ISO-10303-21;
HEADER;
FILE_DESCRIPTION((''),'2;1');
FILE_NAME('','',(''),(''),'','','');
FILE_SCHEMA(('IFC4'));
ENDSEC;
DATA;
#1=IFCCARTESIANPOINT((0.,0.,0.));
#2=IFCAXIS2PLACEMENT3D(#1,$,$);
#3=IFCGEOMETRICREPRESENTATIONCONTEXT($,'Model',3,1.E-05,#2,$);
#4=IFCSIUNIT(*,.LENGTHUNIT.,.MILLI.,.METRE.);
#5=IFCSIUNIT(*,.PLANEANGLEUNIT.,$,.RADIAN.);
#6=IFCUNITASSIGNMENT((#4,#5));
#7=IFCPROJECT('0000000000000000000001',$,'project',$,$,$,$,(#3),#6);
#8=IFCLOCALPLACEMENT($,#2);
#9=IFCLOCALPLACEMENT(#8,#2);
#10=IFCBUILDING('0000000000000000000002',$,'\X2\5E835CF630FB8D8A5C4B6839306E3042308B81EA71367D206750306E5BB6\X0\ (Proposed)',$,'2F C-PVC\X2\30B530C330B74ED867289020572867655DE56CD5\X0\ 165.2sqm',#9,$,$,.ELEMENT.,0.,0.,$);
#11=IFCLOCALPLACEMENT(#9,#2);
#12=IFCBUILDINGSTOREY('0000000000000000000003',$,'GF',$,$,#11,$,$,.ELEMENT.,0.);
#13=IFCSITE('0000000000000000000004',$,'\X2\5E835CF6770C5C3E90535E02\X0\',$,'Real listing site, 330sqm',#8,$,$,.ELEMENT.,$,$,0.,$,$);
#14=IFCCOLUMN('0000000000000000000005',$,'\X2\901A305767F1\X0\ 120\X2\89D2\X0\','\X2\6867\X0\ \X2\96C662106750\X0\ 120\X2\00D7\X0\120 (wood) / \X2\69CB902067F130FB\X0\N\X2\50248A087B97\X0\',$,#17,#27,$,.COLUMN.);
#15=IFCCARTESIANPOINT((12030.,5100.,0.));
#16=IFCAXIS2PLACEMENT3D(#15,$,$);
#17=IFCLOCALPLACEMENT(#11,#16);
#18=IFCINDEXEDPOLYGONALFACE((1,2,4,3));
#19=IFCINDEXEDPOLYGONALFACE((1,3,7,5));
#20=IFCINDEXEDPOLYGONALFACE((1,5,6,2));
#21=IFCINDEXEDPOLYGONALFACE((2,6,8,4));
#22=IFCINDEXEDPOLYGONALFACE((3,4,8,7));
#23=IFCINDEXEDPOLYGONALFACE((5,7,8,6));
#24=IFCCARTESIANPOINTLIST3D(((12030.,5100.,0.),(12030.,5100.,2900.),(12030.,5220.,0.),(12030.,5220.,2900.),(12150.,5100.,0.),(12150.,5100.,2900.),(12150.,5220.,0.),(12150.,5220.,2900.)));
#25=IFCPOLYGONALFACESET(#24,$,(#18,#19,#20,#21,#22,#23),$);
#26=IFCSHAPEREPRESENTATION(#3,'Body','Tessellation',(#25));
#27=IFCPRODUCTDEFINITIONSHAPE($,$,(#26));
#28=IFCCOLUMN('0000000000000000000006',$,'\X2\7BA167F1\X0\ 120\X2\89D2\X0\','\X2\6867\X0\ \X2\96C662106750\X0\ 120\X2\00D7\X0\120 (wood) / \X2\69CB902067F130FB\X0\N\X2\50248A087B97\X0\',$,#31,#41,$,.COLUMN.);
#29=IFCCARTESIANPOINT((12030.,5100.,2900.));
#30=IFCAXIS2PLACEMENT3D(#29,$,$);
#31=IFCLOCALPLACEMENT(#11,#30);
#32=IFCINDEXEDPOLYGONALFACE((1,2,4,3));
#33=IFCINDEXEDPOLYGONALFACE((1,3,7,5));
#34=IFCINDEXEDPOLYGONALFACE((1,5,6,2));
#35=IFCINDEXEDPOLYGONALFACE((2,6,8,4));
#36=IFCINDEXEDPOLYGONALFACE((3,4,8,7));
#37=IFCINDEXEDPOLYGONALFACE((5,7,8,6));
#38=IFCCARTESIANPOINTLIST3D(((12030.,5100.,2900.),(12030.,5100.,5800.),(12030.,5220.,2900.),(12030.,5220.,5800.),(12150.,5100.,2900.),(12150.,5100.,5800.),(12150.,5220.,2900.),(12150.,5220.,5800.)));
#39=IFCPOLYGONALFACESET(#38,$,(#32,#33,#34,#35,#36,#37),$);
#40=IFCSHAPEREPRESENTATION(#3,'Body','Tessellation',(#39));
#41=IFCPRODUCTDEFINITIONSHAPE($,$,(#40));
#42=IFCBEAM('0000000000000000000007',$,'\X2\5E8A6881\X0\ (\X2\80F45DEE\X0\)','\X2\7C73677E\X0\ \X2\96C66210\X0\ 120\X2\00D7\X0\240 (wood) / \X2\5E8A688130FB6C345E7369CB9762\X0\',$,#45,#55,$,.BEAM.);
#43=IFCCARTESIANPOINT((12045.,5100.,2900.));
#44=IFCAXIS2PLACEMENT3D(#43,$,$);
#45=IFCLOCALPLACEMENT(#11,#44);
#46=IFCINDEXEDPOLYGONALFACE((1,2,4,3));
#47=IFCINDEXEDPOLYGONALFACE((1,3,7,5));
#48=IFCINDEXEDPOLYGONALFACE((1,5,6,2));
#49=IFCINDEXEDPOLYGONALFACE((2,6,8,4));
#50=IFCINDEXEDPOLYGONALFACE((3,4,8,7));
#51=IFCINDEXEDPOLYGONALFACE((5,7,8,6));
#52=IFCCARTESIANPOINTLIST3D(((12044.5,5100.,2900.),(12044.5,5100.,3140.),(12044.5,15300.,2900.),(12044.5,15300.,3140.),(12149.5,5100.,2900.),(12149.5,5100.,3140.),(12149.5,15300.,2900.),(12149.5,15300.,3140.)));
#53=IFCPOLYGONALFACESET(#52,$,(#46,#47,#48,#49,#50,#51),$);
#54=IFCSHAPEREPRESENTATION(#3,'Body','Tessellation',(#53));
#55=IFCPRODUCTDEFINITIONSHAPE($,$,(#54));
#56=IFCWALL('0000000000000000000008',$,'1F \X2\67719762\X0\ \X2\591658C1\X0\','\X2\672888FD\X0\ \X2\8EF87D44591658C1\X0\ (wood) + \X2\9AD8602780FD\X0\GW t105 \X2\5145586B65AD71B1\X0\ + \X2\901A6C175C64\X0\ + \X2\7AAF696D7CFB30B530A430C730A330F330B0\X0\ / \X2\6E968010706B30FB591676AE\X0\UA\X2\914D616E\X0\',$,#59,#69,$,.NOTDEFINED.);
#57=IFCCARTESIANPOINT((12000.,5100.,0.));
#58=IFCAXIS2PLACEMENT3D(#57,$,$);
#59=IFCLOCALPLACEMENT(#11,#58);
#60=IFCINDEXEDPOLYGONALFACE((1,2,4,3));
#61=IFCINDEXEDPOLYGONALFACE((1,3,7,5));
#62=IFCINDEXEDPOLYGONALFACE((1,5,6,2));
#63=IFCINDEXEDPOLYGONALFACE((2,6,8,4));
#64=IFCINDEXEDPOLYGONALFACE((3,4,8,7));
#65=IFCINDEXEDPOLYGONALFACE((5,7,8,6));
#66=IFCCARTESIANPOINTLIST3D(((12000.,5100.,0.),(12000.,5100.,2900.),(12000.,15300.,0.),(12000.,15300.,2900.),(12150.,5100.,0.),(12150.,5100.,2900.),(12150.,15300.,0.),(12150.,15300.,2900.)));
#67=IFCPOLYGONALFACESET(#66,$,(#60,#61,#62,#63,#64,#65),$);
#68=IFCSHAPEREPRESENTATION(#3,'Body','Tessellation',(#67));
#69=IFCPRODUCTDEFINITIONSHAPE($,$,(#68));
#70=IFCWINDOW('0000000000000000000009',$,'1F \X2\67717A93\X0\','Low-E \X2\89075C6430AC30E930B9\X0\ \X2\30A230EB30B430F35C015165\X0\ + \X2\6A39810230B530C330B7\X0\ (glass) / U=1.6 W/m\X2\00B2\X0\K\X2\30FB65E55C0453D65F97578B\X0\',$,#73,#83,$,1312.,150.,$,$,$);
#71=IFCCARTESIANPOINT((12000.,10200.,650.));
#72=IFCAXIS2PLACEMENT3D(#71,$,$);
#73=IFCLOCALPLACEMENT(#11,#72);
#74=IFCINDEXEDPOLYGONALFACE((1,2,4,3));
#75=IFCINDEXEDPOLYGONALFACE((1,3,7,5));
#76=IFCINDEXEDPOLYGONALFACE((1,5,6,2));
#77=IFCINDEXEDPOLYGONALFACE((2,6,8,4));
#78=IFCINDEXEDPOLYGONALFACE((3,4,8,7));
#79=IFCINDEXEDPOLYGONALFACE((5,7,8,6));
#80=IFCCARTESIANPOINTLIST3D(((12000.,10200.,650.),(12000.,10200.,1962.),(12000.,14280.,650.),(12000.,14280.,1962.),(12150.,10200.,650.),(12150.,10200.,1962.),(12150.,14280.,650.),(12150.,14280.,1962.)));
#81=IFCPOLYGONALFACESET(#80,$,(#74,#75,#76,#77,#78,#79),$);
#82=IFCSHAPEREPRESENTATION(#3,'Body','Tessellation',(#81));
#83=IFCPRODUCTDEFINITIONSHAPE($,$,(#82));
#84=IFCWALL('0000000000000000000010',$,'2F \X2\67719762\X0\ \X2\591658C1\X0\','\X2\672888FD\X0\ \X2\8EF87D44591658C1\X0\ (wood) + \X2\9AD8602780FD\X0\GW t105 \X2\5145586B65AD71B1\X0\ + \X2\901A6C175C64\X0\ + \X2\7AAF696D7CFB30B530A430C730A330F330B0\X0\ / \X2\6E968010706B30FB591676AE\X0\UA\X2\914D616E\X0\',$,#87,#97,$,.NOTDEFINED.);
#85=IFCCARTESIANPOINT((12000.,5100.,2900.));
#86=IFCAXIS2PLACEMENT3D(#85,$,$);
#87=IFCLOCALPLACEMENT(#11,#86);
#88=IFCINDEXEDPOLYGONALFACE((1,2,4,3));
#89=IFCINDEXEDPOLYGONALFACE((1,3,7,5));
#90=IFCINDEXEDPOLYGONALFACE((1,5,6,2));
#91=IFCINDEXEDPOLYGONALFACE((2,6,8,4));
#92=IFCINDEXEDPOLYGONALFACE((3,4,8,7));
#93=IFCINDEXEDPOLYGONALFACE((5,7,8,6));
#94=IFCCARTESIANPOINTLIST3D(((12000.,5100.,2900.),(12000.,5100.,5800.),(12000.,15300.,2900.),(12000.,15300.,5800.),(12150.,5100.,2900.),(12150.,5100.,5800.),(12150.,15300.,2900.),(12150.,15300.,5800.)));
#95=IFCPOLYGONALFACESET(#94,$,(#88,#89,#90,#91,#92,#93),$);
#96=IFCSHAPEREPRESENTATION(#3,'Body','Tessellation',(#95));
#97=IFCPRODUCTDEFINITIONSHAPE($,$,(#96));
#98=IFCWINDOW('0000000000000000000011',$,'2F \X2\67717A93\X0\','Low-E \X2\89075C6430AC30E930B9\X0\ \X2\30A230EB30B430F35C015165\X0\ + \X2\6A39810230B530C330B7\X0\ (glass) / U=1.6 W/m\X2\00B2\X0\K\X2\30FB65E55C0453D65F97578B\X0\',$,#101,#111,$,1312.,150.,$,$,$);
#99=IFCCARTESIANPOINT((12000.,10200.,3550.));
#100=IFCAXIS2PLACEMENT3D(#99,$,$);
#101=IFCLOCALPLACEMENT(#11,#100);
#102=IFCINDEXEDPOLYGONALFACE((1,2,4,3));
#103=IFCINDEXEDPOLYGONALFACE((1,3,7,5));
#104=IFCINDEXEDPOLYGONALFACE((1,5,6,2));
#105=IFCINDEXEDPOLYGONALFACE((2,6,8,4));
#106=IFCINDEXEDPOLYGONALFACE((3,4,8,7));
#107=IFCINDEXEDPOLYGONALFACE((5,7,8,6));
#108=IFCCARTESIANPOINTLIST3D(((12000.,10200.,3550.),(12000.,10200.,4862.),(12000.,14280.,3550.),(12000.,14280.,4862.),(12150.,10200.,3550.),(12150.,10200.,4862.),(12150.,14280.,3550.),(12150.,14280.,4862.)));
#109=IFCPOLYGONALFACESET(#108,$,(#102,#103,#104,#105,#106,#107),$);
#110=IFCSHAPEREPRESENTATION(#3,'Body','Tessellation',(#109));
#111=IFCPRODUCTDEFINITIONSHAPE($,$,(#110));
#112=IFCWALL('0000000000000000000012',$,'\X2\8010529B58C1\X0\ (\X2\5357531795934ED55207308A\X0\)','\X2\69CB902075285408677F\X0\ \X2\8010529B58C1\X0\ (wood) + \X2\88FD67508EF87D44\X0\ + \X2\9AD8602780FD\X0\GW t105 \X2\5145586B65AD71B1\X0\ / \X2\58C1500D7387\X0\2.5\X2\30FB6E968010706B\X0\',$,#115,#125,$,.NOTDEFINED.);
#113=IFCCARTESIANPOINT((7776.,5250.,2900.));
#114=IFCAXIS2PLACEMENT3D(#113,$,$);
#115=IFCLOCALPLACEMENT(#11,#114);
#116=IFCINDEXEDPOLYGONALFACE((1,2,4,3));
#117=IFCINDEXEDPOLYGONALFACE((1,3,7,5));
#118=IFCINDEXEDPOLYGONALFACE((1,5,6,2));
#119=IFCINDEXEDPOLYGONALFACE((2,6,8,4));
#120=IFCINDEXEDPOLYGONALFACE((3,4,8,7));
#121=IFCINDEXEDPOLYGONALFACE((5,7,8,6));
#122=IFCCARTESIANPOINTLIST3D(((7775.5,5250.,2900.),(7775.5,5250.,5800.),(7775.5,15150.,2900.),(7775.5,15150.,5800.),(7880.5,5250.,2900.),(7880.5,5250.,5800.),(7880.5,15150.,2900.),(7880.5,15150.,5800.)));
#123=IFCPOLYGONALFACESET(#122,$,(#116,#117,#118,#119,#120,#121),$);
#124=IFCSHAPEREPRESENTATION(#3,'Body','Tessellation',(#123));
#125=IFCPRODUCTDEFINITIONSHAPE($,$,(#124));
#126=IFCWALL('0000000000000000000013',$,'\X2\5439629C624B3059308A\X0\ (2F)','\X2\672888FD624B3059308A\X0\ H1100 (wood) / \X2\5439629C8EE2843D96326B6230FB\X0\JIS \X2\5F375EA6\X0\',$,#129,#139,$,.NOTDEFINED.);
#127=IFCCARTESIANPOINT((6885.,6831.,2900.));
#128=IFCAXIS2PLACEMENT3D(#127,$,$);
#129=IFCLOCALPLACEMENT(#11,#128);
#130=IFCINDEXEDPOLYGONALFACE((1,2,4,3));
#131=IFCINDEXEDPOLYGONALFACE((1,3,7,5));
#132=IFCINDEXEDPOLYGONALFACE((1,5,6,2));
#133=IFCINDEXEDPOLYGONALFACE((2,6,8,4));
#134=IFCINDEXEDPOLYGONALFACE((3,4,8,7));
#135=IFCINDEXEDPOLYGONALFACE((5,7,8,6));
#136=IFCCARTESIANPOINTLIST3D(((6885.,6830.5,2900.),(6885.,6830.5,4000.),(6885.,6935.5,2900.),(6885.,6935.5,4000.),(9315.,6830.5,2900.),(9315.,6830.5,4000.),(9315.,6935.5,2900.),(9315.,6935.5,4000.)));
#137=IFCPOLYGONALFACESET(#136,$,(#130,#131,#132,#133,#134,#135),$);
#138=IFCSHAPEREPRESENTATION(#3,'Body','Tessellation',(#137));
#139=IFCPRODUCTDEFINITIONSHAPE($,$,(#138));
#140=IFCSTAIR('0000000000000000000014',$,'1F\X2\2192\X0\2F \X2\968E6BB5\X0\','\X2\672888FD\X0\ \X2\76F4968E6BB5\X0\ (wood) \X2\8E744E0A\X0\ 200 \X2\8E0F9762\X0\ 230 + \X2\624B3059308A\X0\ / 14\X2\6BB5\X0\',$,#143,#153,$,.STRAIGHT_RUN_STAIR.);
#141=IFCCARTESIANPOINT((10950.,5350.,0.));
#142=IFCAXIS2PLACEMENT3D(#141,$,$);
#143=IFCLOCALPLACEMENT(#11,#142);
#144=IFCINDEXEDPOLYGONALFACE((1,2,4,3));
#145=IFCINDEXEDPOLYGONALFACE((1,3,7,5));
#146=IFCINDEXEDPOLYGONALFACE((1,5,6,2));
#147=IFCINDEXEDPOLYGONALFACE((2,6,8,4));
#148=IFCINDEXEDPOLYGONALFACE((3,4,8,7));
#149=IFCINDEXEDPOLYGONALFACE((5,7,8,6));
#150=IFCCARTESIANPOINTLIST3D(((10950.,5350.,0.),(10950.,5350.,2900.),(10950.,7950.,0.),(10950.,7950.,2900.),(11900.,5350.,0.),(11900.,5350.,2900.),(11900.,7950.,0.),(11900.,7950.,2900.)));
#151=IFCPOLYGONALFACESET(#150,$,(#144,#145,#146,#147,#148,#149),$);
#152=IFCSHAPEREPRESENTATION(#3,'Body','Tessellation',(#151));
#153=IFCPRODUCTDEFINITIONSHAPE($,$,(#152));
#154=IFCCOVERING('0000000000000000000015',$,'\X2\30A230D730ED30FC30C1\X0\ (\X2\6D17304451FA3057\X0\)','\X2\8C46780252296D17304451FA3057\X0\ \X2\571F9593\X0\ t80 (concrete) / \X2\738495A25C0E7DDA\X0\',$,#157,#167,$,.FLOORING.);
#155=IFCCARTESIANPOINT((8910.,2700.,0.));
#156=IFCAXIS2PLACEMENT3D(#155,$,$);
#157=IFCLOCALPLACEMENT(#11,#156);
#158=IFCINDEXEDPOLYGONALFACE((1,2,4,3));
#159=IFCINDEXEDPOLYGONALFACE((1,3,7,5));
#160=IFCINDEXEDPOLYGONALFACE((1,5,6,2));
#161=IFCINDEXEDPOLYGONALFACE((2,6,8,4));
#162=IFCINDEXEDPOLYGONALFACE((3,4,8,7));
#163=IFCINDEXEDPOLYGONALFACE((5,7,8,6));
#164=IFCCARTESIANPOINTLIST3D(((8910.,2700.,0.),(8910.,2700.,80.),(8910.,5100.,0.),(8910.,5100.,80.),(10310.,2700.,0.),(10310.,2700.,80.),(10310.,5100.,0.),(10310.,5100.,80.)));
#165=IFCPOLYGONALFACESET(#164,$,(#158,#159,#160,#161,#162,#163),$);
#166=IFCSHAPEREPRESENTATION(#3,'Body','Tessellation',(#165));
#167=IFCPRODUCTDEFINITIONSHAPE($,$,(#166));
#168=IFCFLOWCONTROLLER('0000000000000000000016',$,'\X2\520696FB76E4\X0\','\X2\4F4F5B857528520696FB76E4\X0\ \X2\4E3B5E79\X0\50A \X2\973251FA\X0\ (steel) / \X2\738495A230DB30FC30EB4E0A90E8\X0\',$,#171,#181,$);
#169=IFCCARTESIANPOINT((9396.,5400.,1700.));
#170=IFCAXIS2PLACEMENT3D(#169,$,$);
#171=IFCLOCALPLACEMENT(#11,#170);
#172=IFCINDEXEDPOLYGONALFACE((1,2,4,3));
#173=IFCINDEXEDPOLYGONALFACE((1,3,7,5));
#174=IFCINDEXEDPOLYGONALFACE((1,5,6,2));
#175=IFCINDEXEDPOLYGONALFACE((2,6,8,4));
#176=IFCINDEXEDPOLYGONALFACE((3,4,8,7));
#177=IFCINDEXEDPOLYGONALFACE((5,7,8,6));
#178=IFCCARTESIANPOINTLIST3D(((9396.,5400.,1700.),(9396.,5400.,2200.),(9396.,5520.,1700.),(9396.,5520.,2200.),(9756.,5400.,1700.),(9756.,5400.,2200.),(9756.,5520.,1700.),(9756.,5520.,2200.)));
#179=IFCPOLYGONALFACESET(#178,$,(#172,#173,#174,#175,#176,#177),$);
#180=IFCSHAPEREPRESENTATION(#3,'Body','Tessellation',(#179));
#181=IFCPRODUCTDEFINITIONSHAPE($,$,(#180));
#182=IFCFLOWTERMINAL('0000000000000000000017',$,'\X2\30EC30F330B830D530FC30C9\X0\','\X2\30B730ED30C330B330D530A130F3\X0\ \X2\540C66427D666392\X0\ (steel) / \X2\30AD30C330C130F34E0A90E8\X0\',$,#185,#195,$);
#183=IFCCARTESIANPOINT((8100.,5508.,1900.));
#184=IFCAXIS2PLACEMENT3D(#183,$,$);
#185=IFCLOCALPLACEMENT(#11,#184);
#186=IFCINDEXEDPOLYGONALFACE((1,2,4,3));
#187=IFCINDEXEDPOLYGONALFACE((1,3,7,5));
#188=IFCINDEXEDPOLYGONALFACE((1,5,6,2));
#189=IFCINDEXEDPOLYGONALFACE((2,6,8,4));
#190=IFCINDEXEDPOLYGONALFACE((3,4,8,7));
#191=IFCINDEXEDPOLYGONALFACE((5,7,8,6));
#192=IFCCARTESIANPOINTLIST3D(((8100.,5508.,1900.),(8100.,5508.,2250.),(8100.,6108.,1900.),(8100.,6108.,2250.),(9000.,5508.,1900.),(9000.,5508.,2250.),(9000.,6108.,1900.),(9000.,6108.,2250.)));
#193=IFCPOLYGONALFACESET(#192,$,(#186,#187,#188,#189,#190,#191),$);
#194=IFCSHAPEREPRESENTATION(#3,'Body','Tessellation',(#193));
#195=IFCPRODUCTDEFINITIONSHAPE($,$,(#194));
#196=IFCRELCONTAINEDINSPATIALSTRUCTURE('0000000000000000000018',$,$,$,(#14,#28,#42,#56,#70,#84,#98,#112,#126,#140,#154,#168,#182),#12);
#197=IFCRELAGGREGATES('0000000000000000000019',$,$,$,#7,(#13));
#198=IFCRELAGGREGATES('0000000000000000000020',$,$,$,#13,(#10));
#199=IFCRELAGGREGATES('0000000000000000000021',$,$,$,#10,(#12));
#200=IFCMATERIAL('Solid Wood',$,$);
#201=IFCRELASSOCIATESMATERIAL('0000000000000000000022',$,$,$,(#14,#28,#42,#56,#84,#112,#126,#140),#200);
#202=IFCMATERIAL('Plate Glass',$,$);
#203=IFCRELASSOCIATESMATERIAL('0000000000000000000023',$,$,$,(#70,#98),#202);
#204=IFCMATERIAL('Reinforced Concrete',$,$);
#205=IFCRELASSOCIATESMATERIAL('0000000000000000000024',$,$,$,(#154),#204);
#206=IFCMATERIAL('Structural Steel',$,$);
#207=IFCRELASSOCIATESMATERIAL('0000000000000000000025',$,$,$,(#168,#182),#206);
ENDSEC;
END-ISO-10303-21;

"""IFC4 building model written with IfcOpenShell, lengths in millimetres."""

from ifc_helpers import new_model, si_unit, frame, frame_2d, origin, place, context, project, spatial, rectangle, extrude, material, element, fill, save


model = new_model("IFC4")

# Units and contexts
model_context = context("Model", 3, precision=1e-05, world=origin())
ifc_project = project(units=[si_unit("LENGTHUNIT", "METRE", prefix="MILLI"), si_unit("PLANEANGLEUNIT", "RADIAN")], contexts=[model_context])

# Site, building, storey
site_placement = place(None, origin())
site = spatial("IfcSite", under=ifc_project, at=site_placement, Name="広島県尾道市", ObjectType="Real listing site, 330sqm", CompositionType="ELEMENT", RefElevation=0.0)
building_placement = place(site_placement, origin())
building = spatial("IfcBuilding", under=site, at=building_placement, Name="広島・越屋根のある自然素材の家 (Proposed)", ObjectType="2F C-PVCサッシ付木造在来工法 165.2sqm", CompositionType="ELEMENT", ElevationOfRefHeight=0.0, ElevationOfTerrain=0.0)
storey_placement = place(building_placement, origin())
storey = spatial("IfcBuildingStorey", under=building, at=storey_placement, Name="GF", CompositionType="ELEMENT", Elevation=0.0)

# Columns
ifc_material_1 = material(Name="Solid Wood")
column_1_placement = place(storey_placement, frame((12030.0, 5100.0, 0.0)))
element("IfcColumn", 1, at=column_1_placement, inside=storey, material=ifc_material_1, Name="通し柱 120角", Description="桧 集成材 120×120 (wood) / 構造柱・N値計算", PredefinedType="COLUMN", context=model_context, shape_type="SweptSolid", body=[
    extrude(rectangle(XDim=120.0, YDim=120.0, at=frame_2d((60.0, 60.0))), frame((12030.0, 5100.0, 0.0)), (0.0, 0.0, 1.0), 2900.0),
])
column_2_placement = place(storey_placement, frame((12030.0, 5100.0, 2900.0)))
element("IfcColumn", 2, at=column_2_placement, inside=storey, material=ifc_material_1, Name="管柱 120角", Description="桧 集成材 120×120 (wood) / 構造柱・N値計算", PredefinedType="COLUMN", context=model_context, shape_type="SweptSolid", body=[
    extrude(rectangle(XDim=120.0, YDim=120.0, at=frame_2d((60.0, 60.0))), frame((12030.0, 5100.0, 2900.0)), (0.0, 0.0, 1.0), 2900.0),
])

# Beam
beam_1_placement = place(storey_placement, frame((12045.0, 5100.0, 2900.0)))
element("IfcBeam", 3, at=beam_1_placement, inside=storey, material=ifc_material_1, Name="床梁 (胴差)", Description="米松 集成 120×240 (wood) / 床梁・水平構面", PredefinedType="BEAM", context=model_context, shape_type="SweptSolid", body=[
    extrude(rectangle(XDim=105.0, YDim=10200.0, at=frame_2d((52.0, 5100.0))), frame((12045.0, 5100.0, 2900.0)), (0.0, 0.0, 1.0), 240.0),
])

# Wall, opening, window
wall_1_placement = place(storey_placement, frame((12000.0, 5100.0, 0.0)))
wall_1 = element("IfcWall", 4, at=wall_1_placement, inside=storey, material=ifc_material_1, Name="1F 東面 外壁", Description="木製 軸組外壁 (wood) + 高性能GW t105 充填断熱 + 通気層 + 窯業系サイディング / 準耐火・外皮UA配慮", PredefinedType="NOTDEFINED", context=model_context, shape_type="SweptSolid", body=[
    extrude(rectangle(XDim=150.0, YDim=10200.0, at=frame_2d((75.0, 5100.0))), frame((12000.0, 5100.0, 0.0)), (0.0, 0.0, 1.0), 2900.0),
])
opening_1_placement = place(storey_placement, frame((12000.0, 10200.0, 650.0)))
opening_1 = element("IfcOpeningElement", 5, at=opening_1_placement, cuts=wall_1, PredefinedType="NOTDEFINED", context=model_context, shape_type="SweptSolid", body=[
    extrude(rectangle(XDim=150.0, YDim=4080.0, at=frame_2d((75.0, 2040.0))), frame((12000.0, 10200.0, 650.0)), (0.0, 0.0, 1.0), 1312.0),
])
ifc_material_2 = material(Name="Plate Glass")
window_1_placement = place(storey_placement, frame((12000.0, 10200.0, 650.0)))
window_1 = element("IfcWindow", 6, at=window_1_placement, inside=storey, material=ifc_material_2, Name="1F 東窓", Description="Low-E 複層ガラス アルゴン封入 + 樹脂サッシ (glass) / U=1.6 W/m²K・日射取得型", OverallHeight=1312.0, OverallWidth=150.0, context=model_context, shape_type="SweptSolid", body=[
    extrude(rectangle(XDim=150.0, YDim=4080.0, at=frame_2d((75.0, 2040.0))), frame((12000.0, 10200.0, 650.0)), (0.0, 0.0, 1.0), 1312.0),
])
fill(opening_1, window_1)

# Wall, opening, window
wall_2_placement = place(storey_placement, frame((12000.0, 5100.0, 2900.0)))
wall_2 = element("IfcWall", 7, at=wall_2_placement, inside=storey, material=ifc_material_1, Name="2F 東面 外壁", Description="木製 軸組外壁 (wood) + 高性能GW t105 充填断熱 + 通気層 + 窯業系サイディング / 準耐火・外皮UA配慮", PredefinedType="NOTDEFINED", context=model_context, shape_type="SweptSolid", body=[
    extrude(rectangle(XDim=150.0, YDim=10200.0, at=frame_2d((75.0, 5100.0))), frame((12000.0, 5100.0, 2900.0)), (0.0, 0.0, 1.0), 2900.0),
])
opening_2_placement = place(storey_placement, frame((12000.0, 10200.0, 3550.0)))
opening_2 = element("IfcOpeningElement", 8, at=opening_2_placement, cuts=wall_2, PredefinedType="NOTDEFINED", context=model_context, shape_type="SweptSolid", body=[
    extrude(rectangle(XDim=150.0, YDim=4080.0, at=frame_2d((75.0, 2040.0))), frame((12000.0, 10200.0, 3550.0)), (0.0, 0.0, 1.0), 1312.0),
])
window_2_placement = place(storey_placement, frame((12000.0, 10200.0, 3550.0)))
window_2 = element("IfcWindow", 9, at=window_2_placement, inside=storey, material=ifc_material_2, Name="2F 東窓", Description="Low-E 複層ガラス アルゴン封入 + 樹脂サッシ (glass) / U=1.6 W/m²K・日射取得型", OverallHeight=1312.0, OverallWidth=150.0, context=model_context, shape_type="SweptSolid", body=[
    extrude(rectangle(XDim=150.0, YDim=4080.0, at=frame_2d((75.0, 2040.0))), frame((12000.0, 10200.0, 3550.0)), (0.0, 0.0, 1.0), 1312.0),
])
fill(opening_2, window_2)

# Walls
wall_3_placement = place(storey_placement, frame((7776.0, 5250.0, 2900.0)))
element("IfcWall", 10, at=wall_3_placement, inside=storey, material=ifc_material_1, Name="耐力壁 (南北間仕切り)", Description="構造用合板 耐力壁 (wood) + 製材軸組 + 高性能GW t105 充填断熱 / 壁倍率2.5・準耐火", PredefinedType="NOTDEFINED", context=model_context, shape_type="SweptSolid", body=[
    extrude(rectangle(XDim=105.0, YDim=9900.0, at=frame_2d((52.0, 4950.0))), frame((7776.0, 5250.0, 2900.0)), (0.0, 0.0, 1.0), 2900.0),
])
wall_4_placement = place(storey_placement, frame((6885.0, 6831.0, 2900.0)))
element("IfcWall", 11, at=wall_4_placement, inside=storey, material=ifc_material_1, Name="吹抜手すり (2F)", Description="木製手すり H1100 (wood) / 吹抜転落防止・JIS 強度", PredefinedType="NOTDEFINED", context=model_context, shape_type="SweptSolid", body=[
    extrude(rectangle(XDim=2430.0, YDim=105.0, at=frame_2d((1215.0, 52.0))), frame((6885.0, 6831.0, 2900.0)), (0.0, 0.0, 1.0), 1100.0),
])

# Stair
stair_placement = place(storey_placement, frame((10950.0, 5350.0, 0.0)))
element("IfcStair", 12, at=stair_placement, inside=storey, material=ifc_material_1, Name="1F→2F 階段", Description="木製 直階段 (wood) 蹴上 200 踏面 230 + 手すり / 14段", PredefinedType="STRAIGHT_RUN_STAIR", context=model_context, shape_type="SweptSolid", body=[
    extrude(rectangle(XDim=950.0, YDim=2600.0, at=frame_2d((475.0, 1300.0))), frame((10950.0, 5350.0, 0.0)), (0.0, 0.0, 1.0), 2900.0),
])

# Covering
ifc_material_3 = material(Name="Reinforced Concrete")
covering_placement = place(storey_placement, frame((8910.0, 2700.0, 0.0)))
element("IfcCovering", 13, at=covering_placement, inside=storey, material=ifc_material_3, Name="アプローチ (洗い出し)", Description="豆砂利洗い出し 土間 t80 (concrete) / 玄関導線", PredefinedType="FLOORING", context=model_context, shape_type="SweptSolid", body=[
    extrude(rectangle(XDim=1400.0, YDim=2400.0, at=frame_2d((700.0, 1200.0))), frame((8910.0, 2700.0, 0.0)), (0.0, 0.0, 1.0), 80.0),
])

# Flow controller
ifc_material_4 = material(Name="Structural Steel")
flow_controller_placement = place(storey_placement, frame((9396.0, 5400.0, 1700.0)))
element("IfcFlowController", 14, at=flow_controller_placement, inside=storey, material=ifc_material_4, Name="分電盤", Description="住宅用分電盤 主幹50A 露出 (steel) / 玄関ホール上部", context=model_context, shape_type="SweptSolid", body=[
    extrude(rectangle(XDim=360.0, YDim=120.0, at=frame_2d((180.0, 60.0))), frame((9396.0, 5400.0, 1700.0)), (0.0, 0.0, 1.0), 500.0),
])

# Flow terminal
flow_terminal_1_placement = place(storey_placement, frame((8100.0, 5508.0, 1900.0)))
element("IfcFlowTerminal", 15, at=flow_terminal_1_placement, inside=storey, material=ifc_material_4, Name="レンジフード", Description="シロッコファン 同時給排 (steel) / キッチン上部", context=model_context, shape_type="SweptSolid", body=[
    extrude(rectangle(XDim=900.0, YDim=600.0, at=frame_2d((450.0, 300.0))), frame((8100.0, 5508.0, 1900.0)), (0.0, 0.0, 1.0), 350.0),
])

save(model, "model.ifc")
